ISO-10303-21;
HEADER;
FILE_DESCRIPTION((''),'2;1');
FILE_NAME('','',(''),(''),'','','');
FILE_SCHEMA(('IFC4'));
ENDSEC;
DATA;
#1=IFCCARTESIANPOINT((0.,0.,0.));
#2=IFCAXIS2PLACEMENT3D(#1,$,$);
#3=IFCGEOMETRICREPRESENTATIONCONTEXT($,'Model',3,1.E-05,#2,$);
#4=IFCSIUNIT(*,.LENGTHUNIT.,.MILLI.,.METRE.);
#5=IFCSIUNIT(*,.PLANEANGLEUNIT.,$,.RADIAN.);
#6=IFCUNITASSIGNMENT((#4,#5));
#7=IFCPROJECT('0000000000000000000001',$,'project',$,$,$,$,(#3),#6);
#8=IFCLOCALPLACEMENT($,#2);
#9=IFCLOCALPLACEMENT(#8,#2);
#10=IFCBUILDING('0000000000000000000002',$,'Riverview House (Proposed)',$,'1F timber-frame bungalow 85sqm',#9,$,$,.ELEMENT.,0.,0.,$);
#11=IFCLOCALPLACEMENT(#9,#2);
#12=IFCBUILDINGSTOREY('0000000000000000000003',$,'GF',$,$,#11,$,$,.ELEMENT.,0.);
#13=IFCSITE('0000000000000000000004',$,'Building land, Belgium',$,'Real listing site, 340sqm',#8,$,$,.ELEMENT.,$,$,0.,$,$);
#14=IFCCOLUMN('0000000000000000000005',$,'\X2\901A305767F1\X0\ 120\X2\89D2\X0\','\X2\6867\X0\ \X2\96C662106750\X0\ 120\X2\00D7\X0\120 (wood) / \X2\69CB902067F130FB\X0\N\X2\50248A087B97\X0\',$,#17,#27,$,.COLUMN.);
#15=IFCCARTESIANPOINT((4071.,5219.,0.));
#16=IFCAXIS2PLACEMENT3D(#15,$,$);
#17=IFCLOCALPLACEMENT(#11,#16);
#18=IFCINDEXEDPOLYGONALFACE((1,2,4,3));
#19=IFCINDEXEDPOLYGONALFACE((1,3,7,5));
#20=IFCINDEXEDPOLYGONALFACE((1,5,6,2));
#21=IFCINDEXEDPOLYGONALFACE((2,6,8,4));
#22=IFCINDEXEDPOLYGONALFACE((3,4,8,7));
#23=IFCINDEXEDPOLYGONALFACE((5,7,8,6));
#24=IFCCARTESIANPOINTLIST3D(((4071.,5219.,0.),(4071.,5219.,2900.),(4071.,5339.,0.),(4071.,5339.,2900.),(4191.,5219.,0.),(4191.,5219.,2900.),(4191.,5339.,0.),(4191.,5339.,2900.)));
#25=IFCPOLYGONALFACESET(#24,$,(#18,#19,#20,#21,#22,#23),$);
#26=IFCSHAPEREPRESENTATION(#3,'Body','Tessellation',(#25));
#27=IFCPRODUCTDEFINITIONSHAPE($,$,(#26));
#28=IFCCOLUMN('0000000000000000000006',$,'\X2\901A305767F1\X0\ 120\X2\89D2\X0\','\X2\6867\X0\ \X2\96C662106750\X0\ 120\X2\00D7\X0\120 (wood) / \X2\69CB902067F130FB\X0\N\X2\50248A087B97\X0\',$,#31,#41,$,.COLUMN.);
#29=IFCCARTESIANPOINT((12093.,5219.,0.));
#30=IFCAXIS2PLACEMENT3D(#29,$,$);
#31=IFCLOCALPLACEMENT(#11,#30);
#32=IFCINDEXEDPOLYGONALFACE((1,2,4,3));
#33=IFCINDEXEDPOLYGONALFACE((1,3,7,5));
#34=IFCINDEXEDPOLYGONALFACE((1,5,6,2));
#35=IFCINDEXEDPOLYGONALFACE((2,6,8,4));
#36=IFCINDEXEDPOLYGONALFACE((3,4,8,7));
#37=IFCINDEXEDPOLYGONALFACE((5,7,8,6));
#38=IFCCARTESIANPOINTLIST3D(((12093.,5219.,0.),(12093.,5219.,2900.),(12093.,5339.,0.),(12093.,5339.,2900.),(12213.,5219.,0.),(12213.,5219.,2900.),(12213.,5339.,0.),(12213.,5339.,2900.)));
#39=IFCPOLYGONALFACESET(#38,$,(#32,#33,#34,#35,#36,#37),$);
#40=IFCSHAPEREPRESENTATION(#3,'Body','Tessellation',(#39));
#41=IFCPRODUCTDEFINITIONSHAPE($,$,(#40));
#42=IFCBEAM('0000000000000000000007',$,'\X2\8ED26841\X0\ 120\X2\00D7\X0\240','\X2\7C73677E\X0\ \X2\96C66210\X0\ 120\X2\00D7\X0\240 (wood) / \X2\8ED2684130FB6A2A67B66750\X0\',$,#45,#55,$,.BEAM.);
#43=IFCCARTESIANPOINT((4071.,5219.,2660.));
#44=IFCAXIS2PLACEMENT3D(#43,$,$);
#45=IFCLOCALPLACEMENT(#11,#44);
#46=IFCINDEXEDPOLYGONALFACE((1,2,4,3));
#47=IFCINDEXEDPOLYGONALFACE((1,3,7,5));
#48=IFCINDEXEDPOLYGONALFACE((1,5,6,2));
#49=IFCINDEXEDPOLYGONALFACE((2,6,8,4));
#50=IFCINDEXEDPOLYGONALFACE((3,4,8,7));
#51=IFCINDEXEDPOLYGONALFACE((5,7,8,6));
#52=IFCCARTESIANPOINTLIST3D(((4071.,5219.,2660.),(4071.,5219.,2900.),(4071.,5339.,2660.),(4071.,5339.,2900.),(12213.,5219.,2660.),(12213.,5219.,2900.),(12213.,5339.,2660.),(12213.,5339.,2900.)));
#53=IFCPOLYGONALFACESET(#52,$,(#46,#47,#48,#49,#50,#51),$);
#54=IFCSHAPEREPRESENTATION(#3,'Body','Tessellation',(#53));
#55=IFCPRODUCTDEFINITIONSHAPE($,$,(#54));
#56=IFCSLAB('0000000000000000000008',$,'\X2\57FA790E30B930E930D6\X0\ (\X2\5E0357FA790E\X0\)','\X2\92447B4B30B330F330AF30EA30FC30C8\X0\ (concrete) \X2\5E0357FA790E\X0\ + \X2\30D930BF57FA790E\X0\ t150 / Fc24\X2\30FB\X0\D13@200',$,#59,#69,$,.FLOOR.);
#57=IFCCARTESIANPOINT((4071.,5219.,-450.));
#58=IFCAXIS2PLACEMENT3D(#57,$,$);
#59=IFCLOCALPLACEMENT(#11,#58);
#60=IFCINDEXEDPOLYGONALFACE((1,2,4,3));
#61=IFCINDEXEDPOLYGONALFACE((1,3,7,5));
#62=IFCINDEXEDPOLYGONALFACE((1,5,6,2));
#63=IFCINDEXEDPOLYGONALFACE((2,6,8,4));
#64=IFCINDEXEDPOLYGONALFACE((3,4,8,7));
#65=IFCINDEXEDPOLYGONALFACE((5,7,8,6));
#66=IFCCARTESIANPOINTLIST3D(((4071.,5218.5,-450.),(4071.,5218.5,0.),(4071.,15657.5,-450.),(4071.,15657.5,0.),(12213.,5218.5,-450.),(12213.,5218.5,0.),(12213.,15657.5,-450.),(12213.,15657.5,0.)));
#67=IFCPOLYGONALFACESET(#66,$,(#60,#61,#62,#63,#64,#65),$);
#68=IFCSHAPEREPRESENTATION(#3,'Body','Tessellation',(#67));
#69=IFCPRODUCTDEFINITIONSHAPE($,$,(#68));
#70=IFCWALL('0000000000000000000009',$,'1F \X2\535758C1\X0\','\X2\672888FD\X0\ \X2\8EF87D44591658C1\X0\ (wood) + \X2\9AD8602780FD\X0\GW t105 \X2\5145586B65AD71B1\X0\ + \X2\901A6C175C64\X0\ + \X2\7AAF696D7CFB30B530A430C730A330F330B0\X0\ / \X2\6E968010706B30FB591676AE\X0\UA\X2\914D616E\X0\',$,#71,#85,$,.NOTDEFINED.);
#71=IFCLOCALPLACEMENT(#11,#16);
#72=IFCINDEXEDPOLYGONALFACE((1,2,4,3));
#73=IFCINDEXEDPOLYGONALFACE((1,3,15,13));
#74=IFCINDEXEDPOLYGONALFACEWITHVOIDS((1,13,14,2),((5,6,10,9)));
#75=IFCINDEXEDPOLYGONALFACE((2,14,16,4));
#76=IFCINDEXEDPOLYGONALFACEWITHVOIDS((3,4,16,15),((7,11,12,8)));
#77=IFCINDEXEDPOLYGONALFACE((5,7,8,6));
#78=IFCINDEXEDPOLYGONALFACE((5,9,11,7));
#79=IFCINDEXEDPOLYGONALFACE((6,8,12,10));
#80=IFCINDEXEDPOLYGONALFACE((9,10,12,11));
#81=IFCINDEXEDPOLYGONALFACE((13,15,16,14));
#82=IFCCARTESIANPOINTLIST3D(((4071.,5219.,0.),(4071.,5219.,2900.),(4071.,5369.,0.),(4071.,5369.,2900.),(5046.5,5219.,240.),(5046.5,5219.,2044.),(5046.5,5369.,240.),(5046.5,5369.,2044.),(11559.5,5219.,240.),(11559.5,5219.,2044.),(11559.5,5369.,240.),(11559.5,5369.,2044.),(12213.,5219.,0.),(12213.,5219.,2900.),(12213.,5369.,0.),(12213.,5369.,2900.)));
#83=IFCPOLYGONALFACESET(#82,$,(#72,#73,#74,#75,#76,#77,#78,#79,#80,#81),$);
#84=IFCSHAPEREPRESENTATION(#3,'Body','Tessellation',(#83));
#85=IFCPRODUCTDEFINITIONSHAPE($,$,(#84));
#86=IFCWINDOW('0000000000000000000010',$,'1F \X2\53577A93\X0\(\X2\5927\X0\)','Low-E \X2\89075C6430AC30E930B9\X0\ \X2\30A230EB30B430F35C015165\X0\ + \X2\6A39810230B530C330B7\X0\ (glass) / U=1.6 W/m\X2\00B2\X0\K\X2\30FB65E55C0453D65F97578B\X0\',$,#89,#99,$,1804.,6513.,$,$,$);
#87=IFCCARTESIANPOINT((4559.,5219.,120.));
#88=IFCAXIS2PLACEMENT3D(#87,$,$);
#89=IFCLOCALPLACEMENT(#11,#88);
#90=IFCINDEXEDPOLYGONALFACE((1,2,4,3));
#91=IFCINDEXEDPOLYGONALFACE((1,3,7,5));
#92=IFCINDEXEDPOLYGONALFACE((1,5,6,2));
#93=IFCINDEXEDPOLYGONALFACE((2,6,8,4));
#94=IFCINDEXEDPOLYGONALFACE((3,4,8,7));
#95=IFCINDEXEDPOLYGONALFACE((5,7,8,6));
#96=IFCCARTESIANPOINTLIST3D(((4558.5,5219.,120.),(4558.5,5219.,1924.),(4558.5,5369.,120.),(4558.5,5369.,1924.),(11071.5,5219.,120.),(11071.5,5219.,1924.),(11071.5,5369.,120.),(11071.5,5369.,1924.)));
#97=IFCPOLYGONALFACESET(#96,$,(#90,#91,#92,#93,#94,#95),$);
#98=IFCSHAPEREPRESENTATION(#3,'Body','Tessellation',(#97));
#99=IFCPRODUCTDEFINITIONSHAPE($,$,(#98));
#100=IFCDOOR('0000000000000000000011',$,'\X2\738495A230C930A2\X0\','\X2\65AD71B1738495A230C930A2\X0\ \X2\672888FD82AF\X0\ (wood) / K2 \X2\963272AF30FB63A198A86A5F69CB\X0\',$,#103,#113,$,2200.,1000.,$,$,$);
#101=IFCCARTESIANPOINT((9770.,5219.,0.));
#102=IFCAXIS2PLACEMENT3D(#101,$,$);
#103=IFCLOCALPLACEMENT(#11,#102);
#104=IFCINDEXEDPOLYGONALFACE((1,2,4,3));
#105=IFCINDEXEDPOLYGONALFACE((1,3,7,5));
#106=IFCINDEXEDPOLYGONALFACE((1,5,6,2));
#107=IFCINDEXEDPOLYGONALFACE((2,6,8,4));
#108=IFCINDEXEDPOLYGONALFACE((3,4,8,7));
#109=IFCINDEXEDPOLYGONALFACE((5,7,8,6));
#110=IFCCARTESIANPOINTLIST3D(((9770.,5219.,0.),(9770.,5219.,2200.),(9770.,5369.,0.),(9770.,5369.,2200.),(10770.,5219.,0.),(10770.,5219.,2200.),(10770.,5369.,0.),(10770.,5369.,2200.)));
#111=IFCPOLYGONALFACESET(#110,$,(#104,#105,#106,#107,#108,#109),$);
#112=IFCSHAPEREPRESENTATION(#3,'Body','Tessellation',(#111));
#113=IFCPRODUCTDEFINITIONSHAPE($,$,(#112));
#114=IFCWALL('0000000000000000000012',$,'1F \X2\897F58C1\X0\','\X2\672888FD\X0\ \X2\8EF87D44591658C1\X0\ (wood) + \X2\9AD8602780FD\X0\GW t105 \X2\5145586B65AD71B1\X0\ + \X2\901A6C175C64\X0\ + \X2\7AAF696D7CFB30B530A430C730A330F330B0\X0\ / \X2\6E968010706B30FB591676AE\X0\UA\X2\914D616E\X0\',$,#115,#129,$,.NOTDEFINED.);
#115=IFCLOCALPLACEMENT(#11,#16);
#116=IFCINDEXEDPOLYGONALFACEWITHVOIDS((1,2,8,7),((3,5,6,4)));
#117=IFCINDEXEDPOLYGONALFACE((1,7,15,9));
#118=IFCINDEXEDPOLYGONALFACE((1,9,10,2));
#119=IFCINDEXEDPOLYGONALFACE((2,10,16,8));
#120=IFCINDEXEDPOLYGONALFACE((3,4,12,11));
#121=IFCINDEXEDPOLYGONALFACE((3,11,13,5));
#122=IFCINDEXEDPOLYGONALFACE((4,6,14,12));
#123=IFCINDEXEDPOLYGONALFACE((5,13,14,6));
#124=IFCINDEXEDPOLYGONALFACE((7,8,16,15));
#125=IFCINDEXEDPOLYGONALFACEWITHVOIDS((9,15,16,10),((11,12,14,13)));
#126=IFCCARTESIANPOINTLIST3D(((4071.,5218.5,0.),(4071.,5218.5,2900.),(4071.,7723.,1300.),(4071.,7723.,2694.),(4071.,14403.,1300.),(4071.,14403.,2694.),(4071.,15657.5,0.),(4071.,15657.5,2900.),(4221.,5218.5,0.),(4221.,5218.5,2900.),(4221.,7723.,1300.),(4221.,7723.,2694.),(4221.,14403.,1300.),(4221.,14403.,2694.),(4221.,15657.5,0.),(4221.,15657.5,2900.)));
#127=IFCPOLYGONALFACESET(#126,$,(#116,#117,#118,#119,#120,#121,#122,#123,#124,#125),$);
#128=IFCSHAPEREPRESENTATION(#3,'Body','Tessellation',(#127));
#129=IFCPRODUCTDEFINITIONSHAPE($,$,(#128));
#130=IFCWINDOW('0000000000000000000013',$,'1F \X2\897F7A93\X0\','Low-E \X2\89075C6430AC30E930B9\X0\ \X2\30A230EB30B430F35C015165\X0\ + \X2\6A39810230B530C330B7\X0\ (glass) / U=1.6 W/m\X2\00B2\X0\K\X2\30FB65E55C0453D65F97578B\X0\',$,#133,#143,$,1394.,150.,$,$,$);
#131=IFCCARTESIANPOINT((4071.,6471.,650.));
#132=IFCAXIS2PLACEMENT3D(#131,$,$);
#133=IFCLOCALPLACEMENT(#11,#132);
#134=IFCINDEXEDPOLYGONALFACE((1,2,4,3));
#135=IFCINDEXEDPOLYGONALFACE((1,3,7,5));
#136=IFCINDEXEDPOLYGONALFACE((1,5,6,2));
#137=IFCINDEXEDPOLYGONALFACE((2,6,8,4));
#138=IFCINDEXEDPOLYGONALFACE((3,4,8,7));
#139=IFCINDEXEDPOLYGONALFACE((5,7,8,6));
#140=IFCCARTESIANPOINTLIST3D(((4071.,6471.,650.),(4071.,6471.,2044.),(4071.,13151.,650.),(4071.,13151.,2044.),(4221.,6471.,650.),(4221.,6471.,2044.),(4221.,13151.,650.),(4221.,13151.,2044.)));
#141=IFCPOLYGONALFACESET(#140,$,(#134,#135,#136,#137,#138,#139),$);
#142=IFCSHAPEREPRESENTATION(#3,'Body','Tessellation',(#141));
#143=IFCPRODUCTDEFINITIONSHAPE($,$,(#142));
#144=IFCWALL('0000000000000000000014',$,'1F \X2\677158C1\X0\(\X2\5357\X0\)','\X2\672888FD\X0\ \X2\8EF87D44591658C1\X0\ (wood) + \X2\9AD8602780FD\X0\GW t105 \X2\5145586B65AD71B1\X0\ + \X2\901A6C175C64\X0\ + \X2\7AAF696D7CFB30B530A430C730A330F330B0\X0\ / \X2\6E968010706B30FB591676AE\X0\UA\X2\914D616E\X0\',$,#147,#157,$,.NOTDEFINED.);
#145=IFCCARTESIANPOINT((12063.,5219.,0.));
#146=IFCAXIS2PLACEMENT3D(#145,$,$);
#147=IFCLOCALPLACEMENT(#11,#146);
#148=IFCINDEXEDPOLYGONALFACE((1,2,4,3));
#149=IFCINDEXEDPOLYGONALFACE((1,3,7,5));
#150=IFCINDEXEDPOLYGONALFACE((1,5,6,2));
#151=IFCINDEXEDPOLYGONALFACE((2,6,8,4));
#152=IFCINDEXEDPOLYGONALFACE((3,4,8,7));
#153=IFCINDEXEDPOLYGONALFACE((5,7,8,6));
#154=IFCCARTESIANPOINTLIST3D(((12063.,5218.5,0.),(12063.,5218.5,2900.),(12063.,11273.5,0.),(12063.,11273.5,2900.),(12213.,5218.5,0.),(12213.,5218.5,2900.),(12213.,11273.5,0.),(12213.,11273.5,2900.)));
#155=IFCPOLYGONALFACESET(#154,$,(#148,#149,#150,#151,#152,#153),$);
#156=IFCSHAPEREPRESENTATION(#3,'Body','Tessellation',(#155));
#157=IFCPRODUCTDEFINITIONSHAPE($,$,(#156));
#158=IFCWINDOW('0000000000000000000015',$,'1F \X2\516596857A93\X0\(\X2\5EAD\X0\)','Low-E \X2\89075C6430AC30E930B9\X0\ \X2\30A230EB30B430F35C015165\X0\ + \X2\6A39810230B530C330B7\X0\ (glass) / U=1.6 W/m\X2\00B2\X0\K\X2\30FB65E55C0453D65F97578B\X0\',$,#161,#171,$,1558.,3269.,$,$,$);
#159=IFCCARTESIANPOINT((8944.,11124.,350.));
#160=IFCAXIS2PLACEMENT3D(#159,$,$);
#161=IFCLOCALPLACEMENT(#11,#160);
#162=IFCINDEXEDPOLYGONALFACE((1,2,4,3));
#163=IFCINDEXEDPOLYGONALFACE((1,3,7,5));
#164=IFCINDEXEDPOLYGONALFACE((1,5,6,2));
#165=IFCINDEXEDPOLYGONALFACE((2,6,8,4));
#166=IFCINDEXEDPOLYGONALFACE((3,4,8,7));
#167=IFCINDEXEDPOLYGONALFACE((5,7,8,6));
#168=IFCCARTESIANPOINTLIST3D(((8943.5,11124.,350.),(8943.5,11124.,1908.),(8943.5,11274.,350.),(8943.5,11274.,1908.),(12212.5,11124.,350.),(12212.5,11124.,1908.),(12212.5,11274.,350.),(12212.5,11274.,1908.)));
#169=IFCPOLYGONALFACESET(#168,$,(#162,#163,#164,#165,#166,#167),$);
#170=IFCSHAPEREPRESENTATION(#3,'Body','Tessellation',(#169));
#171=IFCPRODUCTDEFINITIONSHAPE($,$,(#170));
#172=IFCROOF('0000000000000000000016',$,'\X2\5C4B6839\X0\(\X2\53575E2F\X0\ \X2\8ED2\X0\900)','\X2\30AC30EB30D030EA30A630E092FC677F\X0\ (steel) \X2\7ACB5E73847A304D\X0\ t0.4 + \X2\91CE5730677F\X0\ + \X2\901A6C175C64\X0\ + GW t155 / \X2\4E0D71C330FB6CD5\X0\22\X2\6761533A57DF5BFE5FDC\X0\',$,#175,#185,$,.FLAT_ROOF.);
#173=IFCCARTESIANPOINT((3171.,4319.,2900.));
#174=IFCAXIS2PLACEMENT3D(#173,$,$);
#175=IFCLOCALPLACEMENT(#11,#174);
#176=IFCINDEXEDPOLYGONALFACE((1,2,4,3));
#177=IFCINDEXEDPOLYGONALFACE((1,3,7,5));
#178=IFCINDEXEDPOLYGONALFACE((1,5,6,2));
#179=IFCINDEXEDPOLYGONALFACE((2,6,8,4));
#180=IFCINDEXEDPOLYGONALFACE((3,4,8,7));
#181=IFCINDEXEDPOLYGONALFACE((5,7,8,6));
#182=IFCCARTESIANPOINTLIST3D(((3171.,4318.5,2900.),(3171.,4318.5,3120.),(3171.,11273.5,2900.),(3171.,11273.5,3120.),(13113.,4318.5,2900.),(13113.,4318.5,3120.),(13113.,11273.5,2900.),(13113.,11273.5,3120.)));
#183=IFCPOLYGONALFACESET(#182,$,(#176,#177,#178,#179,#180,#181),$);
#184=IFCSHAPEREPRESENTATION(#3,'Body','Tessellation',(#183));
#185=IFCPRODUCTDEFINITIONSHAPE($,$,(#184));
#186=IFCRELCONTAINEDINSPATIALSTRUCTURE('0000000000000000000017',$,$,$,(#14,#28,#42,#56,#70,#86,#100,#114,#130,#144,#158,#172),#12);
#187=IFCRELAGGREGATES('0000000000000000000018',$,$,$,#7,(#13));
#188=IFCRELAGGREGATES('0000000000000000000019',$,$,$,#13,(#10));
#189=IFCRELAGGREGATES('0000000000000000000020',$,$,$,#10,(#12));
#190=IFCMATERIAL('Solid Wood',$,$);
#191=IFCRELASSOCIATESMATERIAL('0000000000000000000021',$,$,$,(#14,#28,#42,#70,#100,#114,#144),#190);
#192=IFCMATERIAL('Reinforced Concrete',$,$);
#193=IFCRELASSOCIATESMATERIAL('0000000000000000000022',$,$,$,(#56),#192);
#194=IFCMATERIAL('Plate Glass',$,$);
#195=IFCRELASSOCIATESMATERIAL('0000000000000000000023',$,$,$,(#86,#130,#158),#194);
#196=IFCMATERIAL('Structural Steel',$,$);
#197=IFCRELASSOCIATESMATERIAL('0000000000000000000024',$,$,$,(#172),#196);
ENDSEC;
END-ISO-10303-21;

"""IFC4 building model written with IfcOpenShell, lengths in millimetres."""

from ifc_helpers import new_model, si_unit, frame, frame_2d, origin, place, context, project, spatial, rectangle, extrude, material, element, fill, save


model = new_model("IFC4")

# Units and contexts
model_context = context("Model", 3, precision=1e-05, world=origin())
ifc_project = project(units=[si_unit("LENGTHUNIT", "METRE", prefix="MILLI"), si_unit("PLANEANGLEUNIT", "RADIAN")], contexts=[model_context])

# Site, building, storey
site_placement = place(None, origin())
site = spatial("IfcSite", under=ifc_project, at=site_placement, Name="Building land, Belgium", ObjectType="Real listing site, 340sqm", CompositionType="ELEMENT", RefElevation=0.0)
building_placement = place(site_placement, origin())
building = spatial("IfcBuilding", under=site, at=building_placement, Name="Riverview House (Proposed)", ObjectType="1F timber-frame bungalow 85sqm", CompositionType="ELEMENT", ElevationOfRefHeight=0.0, ElevationOfTerrain=0.0)
storey_placement = place(building_placement, origin())
storey = spatial("IfcBuildingStorey", under=building, at=storey_placement, Name="GF", CompositionType="ELEMENT", Elevation=0.0)

# Columns
ifc_material_1 = material(Name="Solid Wood")
column_1_placement = place(storey_placement, frame((4071.0, 5219.0, 0.0)))
element("IfcColumn", 1, at=column_1_placement, inside=storey, material=ifc_material_1, Name="通し柱 120角", Description="桧 集成材 120×120 (wood) / 構造柱・N値計算", PredefinedType="COLUMN", context=model_context, shape_type="SweptSolid", body=[
    extrude(rectangle(XDim=120.0, YDim=120.0, at=frame_2d((60.0, 60.0))), frame((4071.0, 5219.0, 0.0)), (0.0, 0.0, 1.0), 2900.0),
])
column_2_placement = place(storey_placement, frame((12093.0, 5219.0, 0.0)))
element("IfcColumn", 2, at=column_2_placement, inside=storey, material=ifc_material_1, Name="通し柱 120角", Description="桧 集成材 120×120 (wood) / 構造柱・N値計算", PredefinedType="COLUMN", context=model_context, shape_type="SweptSolid", body=[
    extrude(rectangle(XDim=120.0, YDim=120.0, at=frame_2d((60.0, 60.0))), frame((12093.0, 5219.0, 0.0)), (0.0, 0.0, 1.0), 2900.0),
])

# Beam
beam_1_placement = place(storey_placement, frame((4071.0, 5219.0, 2660.0)))
element("IfcBeam", 3, at=beam_1_placement, inside=storey, material=ifc_material_1, Name="軒桁 120×240", Description="米松 集成 120×240 (wood) / 軒桁・横架材", PredefinedType="BEAM", context=model_context, shape_type="SweptSolid", body=[
    extrude(rectangle(XDim=8142.0, YDim=120.0, at=frame_2d((4071.0, 60.0))), frame((4071.0, 5219.0, 2660.0)), (0.0, 0.0, 1.0), 240.0),
])

# Slab
ifc_material_2 = material(Name="Reinforced Concrete")
slab_1_placement = place(storey_placement, frame((4071.0, 5219.0, -450.0)))
element("IfcSlab", 4, at=slab_1_placement, inside=storey, material=ifc_material_2, Name="基礎スラブ (布基礎)", Description="鉄筋コンクリート (concrete) 布基礎 + ベタ基礎 t150 / Fc24・D13@200", PredefinedType="FLOOR", context=model_context, shape_type="SweptSolid", body=[
    extrude(rectangle(XDim=8142.0, YDim=10439.0, at=frame_2d((4071.0, 5219.0))), frame((4071.0, 5219.0, -450.0)), (0.0, 0.0, 1.0), 450.0),
])

# Wall, openings, window, door
wall_1_placement = place(storey_placement, frame((4071.0, 5219.0, 0.0)))
wall_1 = element("IfcWall", 5, at=wall_1_placement, inside=storey, material=ifc_material_1, Name="1F 南壁", Description="木製 軸組外壁 (wood) + 高性能GW t105 充填断熱 + 通気層 + 窯業系サイディング / 準耐火・外皮UA配慮", PredefinedType="NOTDEFINED", context=model_context, shape_type="SweptSolid", body=[
    extrude(rectangle(XDim=8142.0, YDim=150.0, at=frame_2d((4071.0, 75.0))), frame((4071.0, 5219.0, 0.0)), (0.0, 0.0, 1.0), 2900.0),
])
opening_1_placement = place(storey_placement, frame((4559.0, 5219.0, 120.0)))
opening_1 = element("IfcOpeningElement", 6, at=opening_1_placement, cuts=wall_1, PredefinedType="NOTDEFINED", context=model_context, shape_type="SweptSolid", body=[
    extrude(rectangle(XDim=6513.0, YDim=150.0, at=frame_2d((3256.0, 75.0))), frame((4559.0, 5219.0, 120.0)), (0.0, 0.0, 1.0), 1804.0),
])
opening_2_placement = place(storey_placement, frame((9770.0, 5219.0, 0.0)))
opening_2 = element("IfcOpeningElement", 7, at=opening_2_placement, cuts=wall_1, PredefinedType="NOTDEFINED", context=model_context, shape_type="SweptSolid", body=[
    extrude(rectangle(XDim=1000.0, YDim=150.0, at=frame_2d((500.0, 75.0))), frame((9770.0, 5219.0, 0.0)), (0.0, 0.0, 1.0), 2200.0),
])
ifc_material_3 = material(Name="Plate Glass")
window_1_placement = place(storey_placement, frame((4559.0, 5219.0, 120.0)))
window_1 = element("IfcWindow", 8, at=window_1_placement, inside=storey, material=ifc_material_3, Name="1F 南窓(大)", Description="Low-E 複層ガラス アルゴン封入 + 樹脂サッシ (glass) / U=1.6 W/m²K・日射取得型", OverallHeight=1804.0, OverallWidth=6513.0, context=model_context, shape_type="SweptSolid", body=[
    extrude(rectangle(XDim=6513.0, YDim=150.0, at=frame_2d((3256.0, 75.0))), frame((4559.0, 5219.0, 120.0)), (0.0, 0.0, 1.0), 1804.0),
])
fill(opening_1, window_1)
door_1_placement = place(storey_placement, frame((9770.0, 5219.0, 0.0)))
door_1 = element("IfcDoor", 9, at=door_1_placement, inside=storey, material=ifc_material_1, Name="玄関ドア", Description="断熱玄関ドア 木製芯 (wood) / K2 防犯・採風機構", OverallHeight=2200.0, OverallWidth=1000.0, context=model_context, shape_type="SweptSolid", body=[
    extrude(rectangle(XDim=1000.0, YDim=150.0, at=frame_2d((500.0, 75.0))), frame((9770.0, 5219.0, 0.0)), (0.0, 0.0, 1.0), 2200.0),
])
fill(opening_2, door_1)

# Walls, openings, windows
wall_2_placement = place(storey_placement, frame((4071.0, 5219.0, 0.0)))
wall_2 = element("IfcWall", 10, at=wall_2_placement, inside=storey, material=ifc_material_1, Name="1F 西壁", Description="木製 軸組外壁 (wood) + 高性能GW t105 充填断熱 + 通気層 + 窯業系サイディング / 準耐火・外皮UA配慮", PredefinedType="NOTDEFINED", context=model_context, shape_type="SweptSolid", body=[
    extrude(rectangle(XDim=150.0, YDim=10439.0, at=frame_2d((75.0, 5219.0))), frame((4071.0, 5219.0, 0.0)), (0.0, 0.0, 1.0), 2900.0),
])
opening_3_placement = place(storey_placement, frame((4071.0, 6471.0, 650.0)))
opening_3 = element("IfcOpeningElement", 11, at=opening_3_placement, cuts=wall_2, PredefinedType="NOTDEFINED", context=model_context, shape_type="SweptSolid", body=[
    extrude(rectangle(XDim=150.0, YDim=6680.0, at=frame_2d((75.0, 3340.0))), frame((4071.0, 6471.0, 650.0)), (0.0, 0.0, 1.0), 1394.0),
])
window_2_placement = place(storey_placement, frame((4071.0, 6471.0, 650.0)))
window_2 = element("IfcWindow", 12, at=window_2_placement, inside=storey, material=ifc_material_3, Name="1F 西窓", Description="Low-E 複層ガラス アルゴン封入 + 樹脂サッシ (glass) / U=1.6 W/m²K・日射取得型", OverallHeight=1394.0, OverallWidth=150.0, context=model_context, shape_type="SweptSolid", body=[
    extrude(rectangle(XDim=150.0, YDim=6680.0, at=frame_2d((75.0, 3340.0))), frame((4071.0, 6471.0, 650.0)), (0.0, 0.0, 1.0), 1394.0),
])
fill(opening_3, window_2)
wall_3_placement = place(storey_placement, frame((12063.0, 5219.0, 0.0)))
wall_3 = element("IfcWall", 13, at=wall_3_placement, inside=storey, material=ifc_material_1, Name="1F 東壁(南)", Description="木製 軸組外壁 (wood) + 高性能GW t105 充填断熱 + 通気層 + 窯業系サイディング / 準耐火・外皮UA配慮", PredefinedType="NOTDEFINED", context=model_context, shape_type="SweptSolid", body=[
    extrude(rectangle(XDim=150.0, YDim=6055.0, at=frame_2d((75.0, 3027.0))), frame((12063.0, 5219.0, 0.0)), (0.0, 0.0, 1.0), 2900.0),
])
opening_4_placement = place(storey_placement, frame((8944.0, 11124.0, 350.0)))
opening_4 = element("IfcOpeningElement", 14, at=opening_4_placement, cuts=wall_3, PredefinedType="NOTDEFINED", context=model_context, shape_type="SweptSolid", body=[
    extrude(rectangle(XDim=3269.0, YDim=150.0, at=frame_2d((1634.0, 75.0))), frame((8944.0, 11124.0, 350.0)), (0.0, 0.0, 1.0), 1558.0),
])
window_3_placement = place(storey_placement, frame((8944.0, 11124.0, 350.0)))
window_3 = element("IfcWindow", 15, at=window_3_placement, inside=storey, material=ifc_material_3, Name="1F 入隅窓(庭)", Description="Low-E 複層ガラス アルゴン封入 + 樹脂サッシ (glass) / U=1.6 W/m²K・日射取得型", OverallHeight=1558.0, OverallWidth=3269.0, context=model_context, shape_type="SweptSolid", body=[
    extrude(rectangle(XDim=3269.0, YDim=150.0, at=frame_2d((1634.0, 75.0))), frame((8944.0, 11124.0, 350.0)), (0.0, 0.0, 1.0), 1558.0),
])
fill(opening_4, window_3)

# Roof
ifc_material_4 = material(Name="Structural Steel")
roof_placement = place(storey_placement, frame((3171.0, 4319.0, 2900.0)))
element("IfcRoof", 16, at=roof_placement, inside=storey, material=ifc_material_4, Name="屋根(南帯 軒900)", Description="ガルバリウム鋼板 (steel) 立平葺き t0.4 + 野地板 + 通気層 + GW t155 / 不燃・法22条区域対応", PredefinedType="FLAT_ROOF", context=model_context, shape_type="SweptSolid", body=[
    extrude(rectangle(XDim=9942.0, YDim=6955.0, at=frame_2d((4971.0, 3477.0))), frame((3171.0, 4319.0, 2900.0)), (0.0, 0.0, 1.0), 220.0),
])

save(model, "model.ifc")
